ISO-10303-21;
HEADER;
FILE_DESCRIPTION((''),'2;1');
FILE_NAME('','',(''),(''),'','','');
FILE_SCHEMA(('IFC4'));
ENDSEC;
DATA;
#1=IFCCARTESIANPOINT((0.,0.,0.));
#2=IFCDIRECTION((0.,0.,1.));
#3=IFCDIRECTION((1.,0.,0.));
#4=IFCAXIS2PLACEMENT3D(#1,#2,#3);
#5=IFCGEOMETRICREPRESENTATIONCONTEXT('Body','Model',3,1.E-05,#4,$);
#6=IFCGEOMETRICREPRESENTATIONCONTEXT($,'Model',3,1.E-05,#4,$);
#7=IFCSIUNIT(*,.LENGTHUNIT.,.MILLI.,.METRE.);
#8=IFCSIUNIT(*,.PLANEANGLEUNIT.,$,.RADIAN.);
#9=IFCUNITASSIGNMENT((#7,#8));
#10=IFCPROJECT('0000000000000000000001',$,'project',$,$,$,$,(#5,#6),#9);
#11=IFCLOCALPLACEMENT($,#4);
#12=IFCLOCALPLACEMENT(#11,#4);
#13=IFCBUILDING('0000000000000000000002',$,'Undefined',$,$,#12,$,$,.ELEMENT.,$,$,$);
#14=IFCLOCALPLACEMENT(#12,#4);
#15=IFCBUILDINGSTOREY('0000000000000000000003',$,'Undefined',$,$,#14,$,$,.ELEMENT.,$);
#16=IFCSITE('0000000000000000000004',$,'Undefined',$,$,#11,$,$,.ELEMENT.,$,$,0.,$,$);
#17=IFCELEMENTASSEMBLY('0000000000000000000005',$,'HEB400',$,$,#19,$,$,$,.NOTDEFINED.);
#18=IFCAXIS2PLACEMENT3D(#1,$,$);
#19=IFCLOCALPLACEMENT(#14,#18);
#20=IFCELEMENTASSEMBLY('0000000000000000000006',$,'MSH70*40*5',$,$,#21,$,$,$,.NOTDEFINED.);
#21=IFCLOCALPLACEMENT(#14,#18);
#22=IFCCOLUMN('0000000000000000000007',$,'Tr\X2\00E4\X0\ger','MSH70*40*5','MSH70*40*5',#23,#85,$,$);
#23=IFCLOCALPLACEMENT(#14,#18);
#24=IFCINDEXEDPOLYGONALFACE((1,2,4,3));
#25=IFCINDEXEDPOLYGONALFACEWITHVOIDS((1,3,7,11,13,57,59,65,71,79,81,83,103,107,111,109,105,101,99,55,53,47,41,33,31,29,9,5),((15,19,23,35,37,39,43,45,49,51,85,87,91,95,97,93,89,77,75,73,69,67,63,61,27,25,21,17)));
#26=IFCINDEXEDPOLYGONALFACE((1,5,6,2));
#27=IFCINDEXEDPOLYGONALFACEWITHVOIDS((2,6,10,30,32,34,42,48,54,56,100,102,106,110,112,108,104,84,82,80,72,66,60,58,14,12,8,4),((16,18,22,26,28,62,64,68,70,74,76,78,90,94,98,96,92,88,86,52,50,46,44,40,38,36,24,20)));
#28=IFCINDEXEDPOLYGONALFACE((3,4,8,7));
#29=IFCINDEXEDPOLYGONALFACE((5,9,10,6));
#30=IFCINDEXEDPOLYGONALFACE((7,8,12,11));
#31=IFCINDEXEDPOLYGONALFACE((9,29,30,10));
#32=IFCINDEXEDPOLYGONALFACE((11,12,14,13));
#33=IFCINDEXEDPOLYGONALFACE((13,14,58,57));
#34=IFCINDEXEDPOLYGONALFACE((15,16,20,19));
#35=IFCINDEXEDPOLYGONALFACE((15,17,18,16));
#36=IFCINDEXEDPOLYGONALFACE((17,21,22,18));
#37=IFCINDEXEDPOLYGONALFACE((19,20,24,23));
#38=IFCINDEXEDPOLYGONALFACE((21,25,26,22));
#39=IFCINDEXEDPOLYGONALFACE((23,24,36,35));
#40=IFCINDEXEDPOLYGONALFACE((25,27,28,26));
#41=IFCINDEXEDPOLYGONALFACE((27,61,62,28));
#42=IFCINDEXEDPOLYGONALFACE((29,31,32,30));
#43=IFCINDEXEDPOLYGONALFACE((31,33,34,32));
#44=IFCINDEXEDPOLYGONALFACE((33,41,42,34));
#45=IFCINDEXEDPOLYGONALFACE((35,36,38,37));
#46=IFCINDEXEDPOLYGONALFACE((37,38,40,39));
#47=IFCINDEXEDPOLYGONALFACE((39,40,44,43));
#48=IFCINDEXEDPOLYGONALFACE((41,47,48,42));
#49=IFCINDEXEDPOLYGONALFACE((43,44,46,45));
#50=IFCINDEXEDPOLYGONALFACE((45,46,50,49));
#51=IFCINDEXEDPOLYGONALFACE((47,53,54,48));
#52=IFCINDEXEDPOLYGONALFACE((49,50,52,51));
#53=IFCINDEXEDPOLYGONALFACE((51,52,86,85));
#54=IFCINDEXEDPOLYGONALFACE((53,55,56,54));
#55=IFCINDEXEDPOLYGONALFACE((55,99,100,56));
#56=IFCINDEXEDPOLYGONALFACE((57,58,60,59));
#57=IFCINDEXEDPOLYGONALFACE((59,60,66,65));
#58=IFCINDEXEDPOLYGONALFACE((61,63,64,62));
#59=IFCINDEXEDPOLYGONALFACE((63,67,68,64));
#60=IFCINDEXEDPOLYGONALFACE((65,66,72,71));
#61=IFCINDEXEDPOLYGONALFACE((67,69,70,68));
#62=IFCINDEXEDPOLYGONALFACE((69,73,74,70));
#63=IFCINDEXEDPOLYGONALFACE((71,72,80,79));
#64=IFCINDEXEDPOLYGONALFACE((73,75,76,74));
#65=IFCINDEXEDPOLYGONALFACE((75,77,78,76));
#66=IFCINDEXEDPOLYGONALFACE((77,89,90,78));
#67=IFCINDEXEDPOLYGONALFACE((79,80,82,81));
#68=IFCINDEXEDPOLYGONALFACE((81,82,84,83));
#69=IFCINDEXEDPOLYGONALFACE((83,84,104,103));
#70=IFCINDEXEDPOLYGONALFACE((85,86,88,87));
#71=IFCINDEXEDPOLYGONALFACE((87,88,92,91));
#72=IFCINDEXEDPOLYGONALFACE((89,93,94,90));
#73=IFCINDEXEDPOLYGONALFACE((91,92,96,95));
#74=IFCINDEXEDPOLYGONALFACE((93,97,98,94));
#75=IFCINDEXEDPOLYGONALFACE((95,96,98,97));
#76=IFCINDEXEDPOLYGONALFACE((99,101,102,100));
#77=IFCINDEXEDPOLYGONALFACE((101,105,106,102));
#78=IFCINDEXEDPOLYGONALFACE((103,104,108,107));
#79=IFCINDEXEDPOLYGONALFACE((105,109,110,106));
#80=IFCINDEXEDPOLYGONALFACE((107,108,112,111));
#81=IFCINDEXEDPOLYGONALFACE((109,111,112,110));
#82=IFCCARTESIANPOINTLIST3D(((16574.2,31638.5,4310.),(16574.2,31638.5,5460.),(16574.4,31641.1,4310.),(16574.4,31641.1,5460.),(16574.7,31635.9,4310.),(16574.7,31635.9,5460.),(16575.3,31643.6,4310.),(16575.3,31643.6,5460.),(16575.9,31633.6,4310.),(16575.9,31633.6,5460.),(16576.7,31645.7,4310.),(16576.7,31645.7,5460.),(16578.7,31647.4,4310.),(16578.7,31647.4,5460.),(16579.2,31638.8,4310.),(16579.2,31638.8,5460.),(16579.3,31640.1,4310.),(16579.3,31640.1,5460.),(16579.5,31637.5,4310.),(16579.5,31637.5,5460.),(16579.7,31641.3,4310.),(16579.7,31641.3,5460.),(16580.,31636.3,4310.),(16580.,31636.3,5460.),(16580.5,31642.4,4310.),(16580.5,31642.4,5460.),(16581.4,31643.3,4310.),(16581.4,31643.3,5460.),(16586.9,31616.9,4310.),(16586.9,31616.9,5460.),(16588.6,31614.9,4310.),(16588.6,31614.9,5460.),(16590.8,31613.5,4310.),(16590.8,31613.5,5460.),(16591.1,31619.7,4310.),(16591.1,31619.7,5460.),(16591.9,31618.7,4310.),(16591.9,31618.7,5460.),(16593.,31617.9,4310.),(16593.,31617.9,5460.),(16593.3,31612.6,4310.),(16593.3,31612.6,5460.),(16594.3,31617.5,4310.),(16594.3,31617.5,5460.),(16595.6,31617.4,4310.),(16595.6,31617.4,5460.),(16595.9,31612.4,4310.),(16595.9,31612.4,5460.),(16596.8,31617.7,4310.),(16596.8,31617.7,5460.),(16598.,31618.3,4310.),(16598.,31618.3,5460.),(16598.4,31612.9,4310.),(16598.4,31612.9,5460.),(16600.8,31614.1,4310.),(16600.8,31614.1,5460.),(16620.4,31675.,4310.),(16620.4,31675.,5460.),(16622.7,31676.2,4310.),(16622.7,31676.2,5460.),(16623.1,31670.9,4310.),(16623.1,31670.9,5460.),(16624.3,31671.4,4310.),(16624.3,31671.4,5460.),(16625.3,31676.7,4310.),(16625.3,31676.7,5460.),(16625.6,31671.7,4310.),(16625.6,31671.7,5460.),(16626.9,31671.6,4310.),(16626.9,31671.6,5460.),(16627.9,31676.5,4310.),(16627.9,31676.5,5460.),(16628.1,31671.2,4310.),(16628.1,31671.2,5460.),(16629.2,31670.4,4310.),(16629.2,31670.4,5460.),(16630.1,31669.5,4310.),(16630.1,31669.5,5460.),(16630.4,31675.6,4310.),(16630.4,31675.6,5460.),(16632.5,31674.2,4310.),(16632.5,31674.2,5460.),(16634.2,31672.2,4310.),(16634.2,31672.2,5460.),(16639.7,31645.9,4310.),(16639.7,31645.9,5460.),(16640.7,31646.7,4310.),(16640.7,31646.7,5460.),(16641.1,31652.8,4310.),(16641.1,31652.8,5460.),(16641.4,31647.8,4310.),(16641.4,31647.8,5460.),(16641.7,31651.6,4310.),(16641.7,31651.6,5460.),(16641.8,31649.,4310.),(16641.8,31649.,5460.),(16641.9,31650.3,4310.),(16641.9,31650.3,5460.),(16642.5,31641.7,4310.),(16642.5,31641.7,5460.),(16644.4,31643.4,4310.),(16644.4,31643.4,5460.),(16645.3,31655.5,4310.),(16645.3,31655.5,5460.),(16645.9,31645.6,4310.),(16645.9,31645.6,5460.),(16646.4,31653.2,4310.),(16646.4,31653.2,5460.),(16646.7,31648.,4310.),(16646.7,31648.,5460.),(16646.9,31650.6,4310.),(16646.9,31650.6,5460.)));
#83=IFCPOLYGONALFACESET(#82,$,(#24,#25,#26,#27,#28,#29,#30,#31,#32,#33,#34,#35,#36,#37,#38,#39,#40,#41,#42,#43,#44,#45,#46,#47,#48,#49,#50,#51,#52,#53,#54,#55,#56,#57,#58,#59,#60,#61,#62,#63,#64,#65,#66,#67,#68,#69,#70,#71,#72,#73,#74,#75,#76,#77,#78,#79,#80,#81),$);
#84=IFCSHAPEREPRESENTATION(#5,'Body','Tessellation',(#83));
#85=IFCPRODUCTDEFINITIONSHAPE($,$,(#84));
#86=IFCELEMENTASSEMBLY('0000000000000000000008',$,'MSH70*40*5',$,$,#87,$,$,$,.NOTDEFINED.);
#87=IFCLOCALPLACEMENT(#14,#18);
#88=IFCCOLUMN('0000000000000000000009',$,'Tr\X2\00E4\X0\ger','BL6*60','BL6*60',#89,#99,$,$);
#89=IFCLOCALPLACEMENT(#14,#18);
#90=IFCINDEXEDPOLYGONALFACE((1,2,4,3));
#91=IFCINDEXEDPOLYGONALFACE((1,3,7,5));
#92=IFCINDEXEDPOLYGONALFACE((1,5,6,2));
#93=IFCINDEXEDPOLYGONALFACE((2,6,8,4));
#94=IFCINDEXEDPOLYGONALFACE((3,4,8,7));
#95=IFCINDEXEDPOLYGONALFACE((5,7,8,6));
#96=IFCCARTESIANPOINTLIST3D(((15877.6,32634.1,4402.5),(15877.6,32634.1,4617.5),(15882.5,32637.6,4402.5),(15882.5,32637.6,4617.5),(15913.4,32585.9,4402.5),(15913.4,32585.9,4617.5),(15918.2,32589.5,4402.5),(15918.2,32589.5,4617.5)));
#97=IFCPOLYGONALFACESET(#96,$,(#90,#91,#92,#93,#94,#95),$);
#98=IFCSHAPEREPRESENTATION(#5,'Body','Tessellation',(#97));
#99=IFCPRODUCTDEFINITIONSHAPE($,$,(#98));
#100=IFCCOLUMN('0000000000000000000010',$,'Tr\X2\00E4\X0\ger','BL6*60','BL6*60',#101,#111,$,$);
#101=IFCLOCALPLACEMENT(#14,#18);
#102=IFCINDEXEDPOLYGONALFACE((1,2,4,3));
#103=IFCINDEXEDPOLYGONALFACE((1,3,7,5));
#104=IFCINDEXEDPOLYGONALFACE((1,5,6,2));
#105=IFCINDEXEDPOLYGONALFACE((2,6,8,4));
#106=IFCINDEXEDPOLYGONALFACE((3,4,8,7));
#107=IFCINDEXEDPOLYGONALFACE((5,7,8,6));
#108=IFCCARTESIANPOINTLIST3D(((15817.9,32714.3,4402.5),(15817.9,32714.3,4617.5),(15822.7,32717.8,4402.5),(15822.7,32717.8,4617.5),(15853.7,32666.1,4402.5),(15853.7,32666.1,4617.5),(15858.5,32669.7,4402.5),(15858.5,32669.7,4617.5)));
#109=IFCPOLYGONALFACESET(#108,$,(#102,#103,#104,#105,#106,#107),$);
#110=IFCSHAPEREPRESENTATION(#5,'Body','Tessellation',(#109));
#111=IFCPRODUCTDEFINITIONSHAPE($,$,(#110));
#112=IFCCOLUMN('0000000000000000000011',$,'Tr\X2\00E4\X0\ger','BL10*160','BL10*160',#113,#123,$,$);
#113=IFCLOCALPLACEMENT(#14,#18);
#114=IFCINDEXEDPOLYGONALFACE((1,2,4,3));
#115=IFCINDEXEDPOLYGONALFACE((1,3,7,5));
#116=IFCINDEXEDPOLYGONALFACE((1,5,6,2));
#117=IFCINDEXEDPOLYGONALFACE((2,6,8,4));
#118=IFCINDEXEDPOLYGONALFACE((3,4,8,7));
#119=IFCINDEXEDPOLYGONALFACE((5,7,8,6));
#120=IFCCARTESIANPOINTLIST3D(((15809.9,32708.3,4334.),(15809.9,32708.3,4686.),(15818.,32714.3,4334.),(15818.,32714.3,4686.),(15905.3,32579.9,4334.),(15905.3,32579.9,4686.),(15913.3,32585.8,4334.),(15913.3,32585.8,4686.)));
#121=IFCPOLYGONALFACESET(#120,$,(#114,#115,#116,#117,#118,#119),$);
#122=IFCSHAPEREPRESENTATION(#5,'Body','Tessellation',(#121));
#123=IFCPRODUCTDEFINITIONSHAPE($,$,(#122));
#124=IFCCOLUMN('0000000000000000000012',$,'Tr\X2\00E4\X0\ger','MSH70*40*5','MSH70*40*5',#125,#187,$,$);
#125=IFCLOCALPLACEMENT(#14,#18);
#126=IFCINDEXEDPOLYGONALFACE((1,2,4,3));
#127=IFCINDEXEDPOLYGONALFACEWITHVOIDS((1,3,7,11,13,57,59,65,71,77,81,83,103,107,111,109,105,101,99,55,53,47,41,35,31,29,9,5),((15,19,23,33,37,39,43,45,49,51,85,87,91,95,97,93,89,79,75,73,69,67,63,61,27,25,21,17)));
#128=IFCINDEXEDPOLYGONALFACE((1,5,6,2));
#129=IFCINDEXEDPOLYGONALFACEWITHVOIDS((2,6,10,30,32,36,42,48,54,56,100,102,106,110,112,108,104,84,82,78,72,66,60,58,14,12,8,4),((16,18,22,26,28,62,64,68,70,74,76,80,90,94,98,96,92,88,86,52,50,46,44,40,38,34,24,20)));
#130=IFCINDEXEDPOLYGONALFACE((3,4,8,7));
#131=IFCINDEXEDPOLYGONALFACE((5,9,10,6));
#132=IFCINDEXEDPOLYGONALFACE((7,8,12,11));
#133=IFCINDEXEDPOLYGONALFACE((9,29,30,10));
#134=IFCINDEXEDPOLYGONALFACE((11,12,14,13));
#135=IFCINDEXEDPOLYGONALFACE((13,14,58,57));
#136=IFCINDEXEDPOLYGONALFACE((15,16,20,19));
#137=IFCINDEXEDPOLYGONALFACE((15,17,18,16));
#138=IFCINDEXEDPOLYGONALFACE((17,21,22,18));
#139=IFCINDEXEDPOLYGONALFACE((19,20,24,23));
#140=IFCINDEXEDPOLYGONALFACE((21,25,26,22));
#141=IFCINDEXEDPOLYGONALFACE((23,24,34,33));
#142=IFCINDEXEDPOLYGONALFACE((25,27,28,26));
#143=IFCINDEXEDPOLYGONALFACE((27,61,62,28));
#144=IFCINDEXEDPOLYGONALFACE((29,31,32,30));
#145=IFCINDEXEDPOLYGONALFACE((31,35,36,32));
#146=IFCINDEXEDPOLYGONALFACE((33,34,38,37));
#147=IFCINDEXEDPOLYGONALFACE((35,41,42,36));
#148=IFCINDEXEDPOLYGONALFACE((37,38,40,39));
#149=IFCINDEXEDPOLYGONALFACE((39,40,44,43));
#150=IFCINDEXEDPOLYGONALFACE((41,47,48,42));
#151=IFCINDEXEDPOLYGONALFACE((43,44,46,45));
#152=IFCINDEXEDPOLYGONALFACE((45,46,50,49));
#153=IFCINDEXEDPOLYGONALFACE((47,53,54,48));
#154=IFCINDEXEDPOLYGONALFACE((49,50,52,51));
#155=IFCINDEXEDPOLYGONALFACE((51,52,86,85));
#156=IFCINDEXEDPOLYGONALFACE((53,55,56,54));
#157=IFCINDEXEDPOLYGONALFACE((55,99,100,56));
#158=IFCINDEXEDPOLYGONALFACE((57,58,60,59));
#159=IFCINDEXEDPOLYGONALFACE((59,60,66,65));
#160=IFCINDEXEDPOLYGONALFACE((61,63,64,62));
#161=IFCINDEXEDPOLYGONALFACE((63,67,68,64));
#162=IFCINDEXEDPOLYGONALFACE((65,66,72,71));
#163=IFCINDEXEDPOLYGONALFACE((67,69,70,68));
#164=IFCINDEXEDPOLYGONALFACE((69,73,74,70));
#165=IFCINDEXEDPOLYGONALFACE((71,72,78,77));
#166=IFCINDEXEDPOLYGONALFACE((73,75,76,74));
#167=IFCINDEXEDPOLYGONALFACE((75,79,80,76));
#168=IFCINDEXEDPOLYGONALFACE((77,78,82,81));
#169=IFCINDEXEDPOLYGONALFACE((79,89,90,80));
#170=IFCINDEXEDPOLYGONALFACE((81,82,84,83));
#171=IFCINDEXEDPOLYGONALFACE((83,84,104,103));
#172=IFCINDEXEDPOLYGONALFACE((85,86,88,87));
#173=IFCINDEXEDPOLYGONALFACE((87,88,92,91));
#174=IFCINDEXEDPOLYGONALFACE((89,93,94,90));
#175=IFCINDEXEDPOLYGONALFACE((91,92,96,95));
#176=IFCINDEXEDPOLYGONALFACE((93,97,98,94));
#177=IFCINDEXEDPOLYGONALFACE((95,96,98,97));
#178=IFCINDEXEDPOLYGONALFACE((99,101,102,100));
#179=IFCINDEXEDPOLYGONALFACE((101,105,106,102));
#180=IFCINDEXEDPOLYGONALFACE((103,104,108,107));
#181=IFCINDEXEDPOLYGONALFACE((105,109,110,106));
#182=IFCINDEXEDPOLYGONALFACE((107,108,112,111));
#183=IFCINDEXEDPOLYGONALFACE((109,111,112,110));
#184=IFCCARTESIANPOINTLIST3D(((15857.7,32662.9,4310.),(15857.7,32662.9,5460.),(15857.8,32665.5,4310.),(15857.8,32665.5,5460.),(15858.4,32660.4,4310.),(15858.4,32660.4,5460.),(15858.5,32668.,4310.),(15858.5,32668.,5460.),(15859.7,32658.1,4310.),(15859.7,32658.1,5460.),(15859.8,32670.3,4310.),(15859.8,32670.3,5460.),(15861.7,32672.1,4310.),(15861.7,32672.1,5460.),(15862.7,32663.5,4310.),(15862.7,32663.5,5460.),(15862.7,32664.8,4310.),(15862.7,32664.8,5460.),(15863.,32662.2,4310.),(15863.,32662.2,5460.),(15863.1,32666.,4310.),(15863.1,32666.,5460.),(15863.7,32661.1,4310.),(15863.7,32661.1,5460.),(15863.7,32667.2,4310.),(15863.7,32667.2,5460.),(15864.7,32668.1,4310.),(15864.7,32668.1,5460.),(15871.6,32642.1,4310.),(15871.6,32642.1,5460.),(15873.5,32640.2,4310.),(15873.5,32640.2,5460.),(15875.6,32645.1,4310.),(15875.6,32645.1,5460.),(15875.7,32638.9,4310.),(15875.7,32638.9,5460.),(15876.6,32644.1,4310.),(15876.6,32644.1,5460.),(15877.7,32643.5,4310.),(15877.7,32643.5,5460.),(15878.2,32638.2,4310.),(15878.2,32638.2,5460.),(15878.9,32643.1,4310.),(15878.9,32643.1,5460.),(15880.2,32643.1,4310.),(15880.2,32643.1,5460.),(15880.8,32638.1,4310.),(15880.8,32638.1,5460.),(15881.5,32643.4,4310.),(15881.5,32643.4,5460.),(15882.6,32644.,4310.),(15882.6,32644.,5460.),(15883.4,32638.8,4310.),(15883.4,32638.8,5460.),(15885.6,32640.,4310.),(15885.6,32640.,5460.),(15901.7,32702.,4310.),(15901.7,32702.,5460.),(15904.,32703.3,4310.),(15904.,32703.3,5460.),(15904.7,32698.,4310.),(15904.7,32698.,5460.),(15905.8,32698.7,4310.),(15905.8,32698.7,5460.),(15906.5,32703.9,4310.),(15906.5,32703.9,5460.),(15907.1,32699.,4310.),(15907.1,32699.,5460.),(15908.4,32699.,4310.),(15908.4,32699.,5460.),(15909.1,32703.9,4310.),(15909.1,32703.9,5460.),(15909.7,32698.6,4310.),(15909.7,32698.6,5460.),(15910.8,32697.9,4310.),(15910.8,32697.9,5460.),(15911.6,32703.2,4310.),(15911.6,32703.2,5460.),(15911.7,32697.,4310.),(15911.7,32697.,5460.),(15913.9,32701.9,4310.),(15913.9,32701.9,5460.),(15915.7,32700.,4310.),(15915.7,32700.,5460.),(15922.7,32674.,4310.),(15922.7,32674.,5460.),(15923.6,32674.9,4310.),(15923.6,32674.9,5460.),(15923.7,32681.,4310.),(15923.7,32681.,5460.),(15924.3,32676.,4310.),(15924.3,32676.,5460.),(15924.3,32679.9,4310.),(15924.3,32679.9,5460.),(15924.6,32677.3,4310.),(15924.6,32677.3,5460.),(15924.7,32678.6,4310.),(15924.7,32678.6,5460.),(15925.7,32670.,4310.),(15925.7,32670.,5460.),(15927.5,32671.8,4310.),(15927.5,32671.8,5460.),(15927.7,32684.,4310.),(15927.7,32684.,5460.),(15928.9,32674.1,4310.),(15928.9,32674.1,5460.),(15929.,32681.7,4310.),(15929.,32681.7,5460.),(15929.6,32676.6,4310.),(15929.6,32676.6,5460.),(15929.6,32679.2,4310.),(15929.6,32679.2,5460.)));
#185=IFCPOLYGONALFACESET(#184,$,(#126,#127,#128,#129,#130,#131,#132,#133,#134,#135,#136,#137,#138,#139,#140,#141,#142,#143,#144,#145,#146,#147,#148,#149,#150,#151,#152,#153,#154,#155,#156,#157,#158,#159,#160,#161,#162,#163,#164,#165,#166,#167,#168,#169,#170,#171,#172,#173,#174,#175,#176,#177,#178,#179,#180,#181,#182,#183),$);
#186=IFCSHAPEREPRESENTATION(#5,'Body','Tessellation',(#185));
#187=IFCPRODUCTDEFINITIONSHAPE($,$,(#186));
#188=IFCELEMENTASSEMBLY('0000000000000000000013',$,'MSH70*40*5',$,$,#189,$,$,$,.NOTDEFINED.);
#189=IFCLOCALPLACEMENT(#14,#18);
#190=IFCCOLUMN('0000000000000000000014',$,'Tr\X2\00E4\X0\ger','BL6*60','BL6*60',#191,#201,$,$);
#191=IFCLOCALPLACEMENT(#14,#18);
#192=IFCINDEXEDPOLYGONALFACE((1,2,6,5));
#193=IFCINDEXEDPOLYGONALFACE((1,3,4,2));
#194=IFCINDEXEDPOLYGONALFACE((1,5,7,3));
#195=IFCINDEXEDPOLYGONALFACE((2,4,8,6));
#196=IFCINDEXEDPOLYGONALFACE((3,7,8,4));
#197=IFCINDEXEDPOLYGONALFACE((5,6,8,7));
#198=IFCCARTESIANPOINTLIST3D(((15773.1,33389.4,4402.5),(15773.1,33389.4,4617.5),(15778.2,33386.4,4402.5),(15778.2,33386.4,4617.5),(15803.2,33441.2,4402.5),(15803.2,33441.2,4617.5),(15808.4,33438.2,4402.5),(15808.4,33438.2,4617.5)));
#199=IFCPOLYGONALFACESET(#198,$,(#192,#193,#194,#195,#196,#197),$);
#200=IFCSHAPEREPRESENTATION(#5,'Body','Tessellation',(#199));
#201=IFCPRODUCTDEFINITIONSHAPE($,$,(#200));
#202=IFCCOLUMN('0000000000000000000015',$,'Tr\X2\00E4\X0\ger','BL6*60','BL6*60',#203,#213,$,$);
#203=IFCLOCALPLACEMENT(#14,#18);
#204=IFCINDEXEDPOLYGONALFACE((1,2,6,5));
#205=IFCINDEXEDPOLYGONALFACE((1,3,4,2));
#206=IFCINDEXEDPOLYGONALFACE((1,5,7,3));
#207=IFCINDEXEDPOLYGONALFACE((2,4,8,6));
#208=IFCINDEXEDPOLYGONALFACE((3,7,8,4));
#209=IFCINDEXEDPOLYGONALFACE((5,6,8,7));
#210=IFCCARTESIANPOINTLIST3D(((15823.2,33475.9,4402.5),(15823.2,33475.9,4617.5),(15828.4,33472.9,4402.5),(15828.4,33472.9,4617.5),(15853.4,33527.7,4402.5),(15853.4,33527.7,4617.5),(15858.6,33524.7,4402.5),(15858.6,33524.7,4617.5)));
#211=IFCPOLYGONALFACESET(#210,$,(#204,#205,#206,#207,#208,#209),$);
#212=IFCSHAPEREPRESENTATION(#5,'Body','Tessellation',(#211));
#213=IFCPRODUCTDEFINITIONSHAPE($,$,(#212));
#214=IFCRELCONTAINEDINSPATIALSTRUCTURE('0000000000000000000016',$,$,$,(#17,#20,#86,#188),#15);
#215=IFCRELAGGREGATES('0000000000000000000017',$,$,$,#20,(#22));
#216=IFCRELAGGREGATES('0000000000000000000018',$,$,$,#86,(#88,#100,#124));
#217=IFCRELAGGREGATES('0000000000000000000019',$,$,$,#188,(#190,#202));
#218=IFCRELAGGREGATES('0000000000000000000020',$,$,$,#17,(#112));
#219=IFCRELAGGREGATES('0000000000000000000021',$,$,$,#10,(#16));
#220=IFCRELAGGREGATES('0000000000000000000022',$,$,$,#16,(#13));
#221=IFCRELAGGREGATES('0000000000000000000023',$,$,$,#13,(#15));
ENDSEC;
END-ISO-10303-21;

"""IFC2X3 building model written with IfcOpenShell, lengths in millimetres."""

from ifc_helpers import new_model, si_unit, frame, origin_with_axes, origin_2d_with_axis, place, context, project, spatial, rectangle, hollow_rectangle, extrude, element, aggregate, save


model = new_model("IFC2X3")

# Units and contexts
model_context_1 = context("Model", 3, precision=1e-05, world=origin_with_axes(), identifier="Body")
model_context_2 = context("Model", 3, precision=1e-05, world=origin_with_axes())
ifc_project = project(units=[si_unit("LENGTHUNIT", "METRE", prefix="MILLI"), si_unit("PLANEANGLEUNIT", "RADIAN")], contexts=[model_context_1, model_context_2])

# Site, building, storey
site_placement = place(None, origin_with_axes())
site = spatial("IfcSite", under=ifc_project, at=site_placement, Name="Undefined", CompositionType="ELEMENT", RefElevation=0.0)
building_placement = place(site_placement, origin_with_axes())
building = spatial("IfcBuilding", under=site, at=building_placement, Name="Undefined", CompositionType="ELEMENT")
storey_placement = place(building_placement, origin_with_axes())
storey = spatial("IfcBuildingStorey", under=building, at=storey_placement, Name="Undefined", CompositionType="ELEMENT")

# Element assembly
assembly_1 = element("IfcElementAssembly", 1, inside=storey, Name="HEB400", PredefinedType="NOTDEFINED")

# Element assembly
assembly_2 = element("IfcElementAssembly", 2, inside=storey, Name="MSH70*40*5", PredefinedType="NOTDEFINED")

# Column
column_1_placement = place(storey_placement, frame((16610.6, 31644.6, 4310.0), z_axis=(0.0, 0.0, 1.0), x_axis=(1.0, 0.0, 0.0)))
column_1 = element("IfcColumn", 3, at=column_1_placement, Name="Träger", Description="MSH70*40*5", ObjectType="MSH70*40*5", context=model_context_1, shape_type="SweptSolid", body=[
    extrude(hollow_rectangle(XDim=40.0, YDim=70.0, WallThickness=5.0, InnerFilletRadius=5.0, OuterFilletRadius=10.0, at=origin_2d_with_axis()), frame((0.0, 0.0, 1150.0), z_axis=(0.0, 0.0, -1.0), x_axis=(-0.551937, 0.833886, 0.0)), (0.0, 0.0, 1.0), 1150.0),
])
aggregate(assembly_2, [column_1])

# Element assembly, columns
assembly_3 = element("IfcElementAssembly", 4, inside=storey, Name="MSH70*40*5", PredefinedType="NOTDEFINED")
column_2_placement = place(storey_placement, frame((15897.9, 32611.8, 4402.5), z_axis=(0.0, 0.0, 1.0), x_axis=(1.0, 0.0, 0.0)))
column_2 = element("IfcColumn", 5, at=column_2_placement, Name="Träger", Description="BL6*60", ObjectType="BL6*60", context=model_context_1, shape_type="SweptSolid", body=[
    extrude(rectangle(XDim=6.0, YDim=60.0, at=origin_2d_with_axis()), frame((0.0, 0.0, 215.0), z_axis=(0.0, 0.0, -1.0), x_axis=(0.802817, 0.596225, 0.0)), (0.0, 0.0, 1.0), 215.0),
])
column_3_placement = place(storey_placement, frame((15838.2, 32692.0, 4402.5), z_axis=(0.0, 0.0, 1.0), x_axis=(1.0, 0.0, 0.0)))
column_3 = element("IfcColumn", 6, at=column_3_placement, Name="Träger", Description="BL6*60", ObjectType="BL6*60", context=model_context_1, shape_type="SweptSolid", body=[
    extrude(rectangle(XDim=6.0, YDim=60.0, at=origin_2d_with_axis()), frame((0.0, 0.0, 215.0), z_axis=(0.0, 0.0, -1.0), x_axis=(0.802817, 0.596225, 0.0)), (0.0, 0.0, 1.0), 215.0),
])

# Columns
column_4_placement = place(storey_placement, frame((15861.6, 32647.1, 4334.0), z_axis=(0.0, 0.0, 1.0), x_axis=(1.0, 0.0, 0.0)))
column_4 = element("IfcColumn", 7, at=column_4_placement, Name="Träger", Description="BL10*160", ObjectType="BL10*160", context=model_context_1, shape_type="SweptSolid", body=[
    extrude(rectangle(XDim=10.0, YDim=160.0, at=origin_2d_with_axis()), frame((0.0, 0.0, 352.0), z_axis=(0.0, 0.0, -1.0), x_axis=(0.802817, 0.596225, 0.0)), (0.0, 0.0, 1.0), 352.0),
])
column_5_placement = place(storey_placement, frame((15893.7, 32671.0, 4310.0), z_axis=(0.0, 0.0, 1.0), x_axis=(1.0, 0.0, 0.0)))
column_5 = element("IfcColumn", 8, at=column_5_placement, Name="Träger", Description="MSH70*40*5", ObjectType="MSH70*40*5", context=model_context_1, shape_type="SweptSolid", body=[
    extrude(hollow_rectangle(XDim=40.0, YDim=70.0, WallThickness=5.0, InnerFilletRadius=5.0, OuterFilletRadius=10.0, at=origin_2d_with_axis()), frame((0.0, 0.0, 1150.0), z_axis=(0.0, 0.0, -1.0), x_axis=(-0.599024, 0.800731, 0.0)), (0.0, 0.0, 1.0), 1150.0),
])
aggregate(assembly_3, [column_2, column_3, column_5])

# Element assembly, columns
assembly_4 = element("IfcElementAssembly", 9, inside=storey, Name="MSH70*40*5", PredefinedType="NOTDEFINED")
column_6_placement = place(storey_placement, frame((15790.7, 33413.8, 4402.5), z_axis=(0.0, 0.0, 1.0), x_axis=(1.0, 0.0, 0.0)))
column_6 = element("IfcColumn", 10, at=column_6_placement, Name="Träger", Description="BL6*60", ObjectType="BL6*60", context=model_context_1, shape_type="SweptSolid", body=[
    extrude(rectangle(XDim=6.0, YDim=60.0, at=origin_2d_with_axis()), frame((0.0, 0.0, 215.0), z_axis=(0.0, 0.0, -1.0), x_axis=(0.864275, -0.50302, 0.0)), (0.0, 0.0, 1.0), 215.0),
])
column_7_placement = place(storey_placement, frame((15840.9, 33500.3, 4402.5), z_axis=(0.0, 0.0, 1.0), x_axis=(1.0, 0.0, 0.0)))
column_7 = element("IfcColumn", 11, at=column_7_placement, Name="Träger", Description="BL6*60", ObjectType="BL6*60", context=model_context_1, shape_type="SweptSolid", body=[
    extrude(rectangle(XDim=6.0, YDim=60.0, at=origin_2d_with_axis()), frame((0.0, 0.0, 215.0), z_axis=(0.0, 0.0, -1.0), x_axis=(0.864275, -0.50302, 0.0)), (0.0, 0.0, 1.0), 215.0),
])

aggregate(assembly_4, [column_6, column_7])
aggregate(assembly_1, [column_4])

save(model, "model.ifc")
